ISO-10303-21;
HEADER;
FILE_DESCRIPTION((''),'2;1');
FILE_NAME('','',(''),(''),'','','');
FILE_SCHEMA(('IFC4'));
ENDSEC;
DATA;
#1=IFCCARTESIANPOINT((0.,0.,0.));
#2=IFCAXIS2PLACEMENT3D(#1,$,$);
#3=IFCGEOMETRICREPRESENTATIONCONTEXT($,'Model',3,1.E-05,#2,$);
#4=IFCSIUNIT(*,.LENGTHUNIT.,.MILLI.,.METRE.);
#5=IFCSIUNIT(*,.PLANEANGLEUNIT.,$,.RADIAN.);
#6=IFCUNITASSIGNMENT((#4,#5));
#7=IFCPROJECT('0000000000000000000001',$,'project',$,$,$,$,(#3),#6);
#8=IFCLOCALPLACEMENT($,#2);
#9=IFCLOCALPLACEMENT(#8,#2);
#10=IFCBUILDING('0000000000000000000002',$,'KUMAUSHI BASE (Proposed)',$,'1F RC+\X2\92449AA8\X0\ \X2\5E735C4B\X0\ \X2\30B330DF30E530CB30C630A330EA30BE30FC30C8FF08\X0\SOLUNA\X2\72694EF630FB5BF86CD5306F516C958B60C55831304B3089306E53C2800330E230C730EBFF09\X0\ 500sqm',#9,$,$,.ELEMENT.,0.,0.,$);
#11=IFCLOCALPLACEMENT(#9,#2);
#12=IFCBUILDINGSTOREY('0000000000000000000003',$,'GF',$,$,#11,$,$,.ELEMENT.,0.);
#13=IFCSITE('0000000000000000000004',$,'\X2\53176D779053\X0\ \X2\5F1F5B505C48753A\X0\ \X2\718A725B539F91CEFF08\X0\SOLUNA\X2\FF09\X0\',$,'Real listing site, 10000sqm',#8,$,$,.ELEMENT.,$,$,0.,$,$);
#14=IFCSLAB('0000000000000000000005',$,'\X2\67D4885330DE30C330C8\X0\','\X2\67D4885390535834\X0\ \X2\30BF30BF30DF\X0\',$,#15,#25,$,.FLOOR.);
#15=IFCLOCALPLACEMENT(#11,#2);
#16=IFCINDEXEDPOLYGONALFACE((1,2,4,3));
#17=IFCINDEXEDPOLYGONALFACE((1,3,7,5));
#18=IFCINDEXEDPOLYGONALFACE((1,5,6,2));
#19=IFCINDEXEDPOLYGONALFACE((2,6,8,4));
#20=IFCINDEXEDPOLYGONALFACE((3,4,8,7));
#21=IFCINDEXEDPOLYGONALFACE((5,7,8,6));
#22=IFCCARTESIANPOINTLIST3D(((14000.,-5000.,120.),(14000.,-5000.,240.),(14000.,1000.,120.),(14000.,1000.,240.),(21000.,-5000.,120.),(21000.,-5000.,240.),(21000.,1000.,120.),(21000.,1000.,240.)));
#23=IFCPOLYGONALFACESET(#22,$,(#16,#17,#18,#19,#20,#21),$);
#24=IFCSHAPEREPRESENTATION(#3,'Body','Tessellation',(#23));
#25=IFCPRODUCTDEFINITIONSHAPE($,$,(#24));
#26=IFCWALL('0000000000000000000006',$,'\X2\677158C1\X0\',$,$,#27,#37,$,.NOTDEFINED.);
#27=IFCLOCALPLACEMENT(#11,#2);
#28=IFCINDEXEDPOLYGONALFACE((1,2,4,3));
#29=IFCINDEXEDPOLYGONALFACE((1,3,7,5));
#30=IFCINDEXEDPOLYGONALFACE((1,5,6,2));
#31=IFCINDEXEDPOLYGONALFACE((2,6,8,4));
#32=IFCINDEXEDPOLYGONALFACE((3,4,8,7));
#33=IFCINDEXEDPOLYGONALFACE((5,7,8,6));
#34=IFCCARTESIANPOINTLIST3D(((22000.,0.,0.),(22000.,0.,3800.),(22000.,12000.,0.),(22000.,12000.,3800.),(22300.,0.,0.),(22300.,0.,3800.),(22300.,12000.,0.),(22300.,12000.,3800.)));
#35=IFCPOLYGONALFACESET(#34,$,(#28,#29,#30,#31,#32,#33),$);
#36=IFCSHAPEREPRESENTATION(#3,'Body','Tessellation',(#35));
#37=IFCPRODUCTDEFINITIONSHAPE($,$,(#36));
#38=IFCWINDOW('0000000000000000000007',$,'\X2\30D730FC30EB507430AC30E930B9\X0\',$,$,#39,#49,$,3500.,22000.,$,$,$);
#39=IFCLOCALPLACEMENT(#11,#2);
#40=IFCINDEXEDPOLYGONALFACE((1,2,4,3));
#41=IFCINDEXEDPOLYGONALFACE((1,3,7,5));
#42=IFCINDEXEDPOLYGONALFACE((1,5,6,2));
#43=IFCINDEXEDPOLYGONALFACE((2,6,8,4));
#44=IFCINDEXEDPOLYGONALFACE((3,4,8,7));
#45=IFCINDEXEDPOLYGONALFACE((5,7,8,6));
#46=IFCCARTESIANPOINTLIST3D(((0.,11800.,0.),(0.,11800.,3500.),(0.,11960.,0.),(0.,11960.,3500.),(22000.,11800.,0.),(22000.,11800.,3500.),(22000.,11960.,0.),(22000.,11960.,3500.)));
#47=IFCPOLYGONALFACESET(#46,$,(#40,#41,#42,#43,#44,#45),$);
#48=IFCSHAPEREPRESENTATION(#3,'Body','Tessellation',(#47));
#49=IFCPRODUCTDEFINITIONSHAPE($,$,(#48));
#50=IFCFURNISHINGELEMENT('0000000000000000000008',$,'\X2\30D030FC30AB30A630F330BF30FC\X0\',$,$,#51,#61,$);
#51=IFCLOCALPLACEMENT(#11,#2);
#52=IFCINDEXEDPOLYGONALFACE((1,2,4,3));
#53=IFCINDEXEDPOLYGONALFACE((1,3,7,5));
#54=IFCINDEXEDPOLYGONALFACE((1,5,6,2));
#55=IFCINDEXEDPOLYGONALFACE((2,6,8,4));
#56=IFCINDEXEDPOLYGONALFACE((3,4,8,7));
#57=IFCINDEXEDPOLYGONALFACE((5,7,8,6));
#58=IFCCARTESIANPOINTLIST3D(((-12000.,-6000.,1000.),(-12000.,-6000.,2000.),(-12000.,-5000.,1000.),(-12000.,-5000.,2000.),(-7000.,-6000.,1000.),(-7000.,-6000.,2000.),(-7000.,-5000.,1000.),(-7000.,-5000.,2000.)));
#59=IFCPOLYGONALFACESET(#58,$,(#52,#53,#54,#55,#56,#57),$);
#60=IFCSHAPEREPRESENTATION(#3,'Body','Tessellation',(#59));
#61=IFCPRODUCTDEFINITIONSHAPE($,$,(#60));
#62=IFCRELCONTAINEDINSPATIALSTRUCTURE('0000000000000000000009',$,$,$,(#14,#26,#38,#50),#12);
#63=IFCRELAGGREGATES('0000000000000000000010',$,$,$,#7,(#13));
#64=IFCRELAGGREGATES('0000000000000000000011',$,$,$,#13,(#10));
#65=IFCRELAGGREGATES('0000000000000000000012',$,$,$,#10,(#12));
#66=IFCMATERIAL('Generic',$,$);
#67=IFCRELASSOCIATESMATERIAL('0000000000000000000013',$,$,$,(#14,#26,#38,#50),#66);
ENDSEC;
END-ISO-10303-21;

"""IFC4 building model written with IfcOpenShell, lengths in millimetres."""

from ifc_helpers import new_model, si_unit, frame, frame_2d, origin, place, context, project, spatial, rectangle, extrude, material, element, fill, save


model = new_model("IFC4")

# Units and contexts
model_context = context("Model", 3, precision=1e-05, world=origin())
ifc_project = project(units=[si_unit("LENGTHUNIT", "METRE", prefix="MILLI"), si_unit("PLANEANGLEUNIT", "RADIAN")], contexts=[model_context])

# Site, building, storey
site_placement = place(None, origin())
site = spatial("IfcSite", under=ifc_project, at=site_placement, Name="北海道 弟子屈町 熊牛原野（SOLUNA）", ObjectType="Real listing site, 10000sqm", CompositionType="ELEMENT", RefElevation=0.0)
building_placement = place(site_placement, origin())
building = spatial("IfcBuilding", under=site, at=building_placement, Name="KUMAUSHI BASE (Proposed)", ObjectType="1F RC+鉄骨 平屋 コミュニティリゾート（SOLUNA物件・寸法は公開情報からの参考モデル） 500sqm", CompositionType="ELEMENT", ElevationOfRefHeight=0.0, ElevationOfTerrain=0.0)
storey_placement = place(building_placement, origin())
storey = spatial("IfcBuildingStorey", under=building, at=storey_placement, Name="GF", CompositionType="ELEMENT", Elevation=0.0)

# Slab
ifc_material_1 = material(Name="Generic")
slab_1_placement = place(storey_placement, frame((7000.0, -2500.0, 60.0)))
element("IfcSlab", 1, at=slab_1_placement, inside=storey, material=ifc_material_1, Name="柔術マット", Description="柔術道場 タタミ", PredefinedType="FLOOR", context=model_context, shape_type="SweptSolid", body=[
    extrude(rectangle(XDim=7000.0, YDim=6000.0, at=frame_2d((3500.0, 3000.0))), frame((7000.0, -2500.0, 60.0)), (0.0, 0.0, 1.0), 120.0),
])

# Wall, opening, window
wall_1_placement = place(storey_placement, frame((11000.0, 0.0, 0.0)))
wall_1 = element("IfcWall", 2, at=wall_1_placement, inside=storey, material=ifc_material_1, Name="東壁", PredefinedType="NOTDEFINED", context=model_context, shape_type="SweptSolid", body=[
    extrude(rectangle(XDim=300.0, YDim=12000.0, at=frame_2d((150.0, 6000.0))), frame((11000.0, 0.0, 0.0)), (0.0, 0.0, 1.0), 3800.0),
])
opening_placement = place(storey_placement, frame((0.0, 5900.0, 0.0)))
opening = element("IfcOpeningElement", 3, at=opening_placement, cuts=wall_1, PredefinedType="NOTDEFINED", context=model_context, shape_type="SweptSolid", body=[
    extrude(rectangle(XDim=22000.0, YDim=160.0, at=frame_2d((11000.0, 80.0))), frame((0.0, 5900.0, 0.0)), (0.0, 0.0, 1.0), 3500.0),
])
window_placement = place(storey_placement, frame((0.0, 5900.0, 0.0)))
window = element("IfcWindow", 4, at=window_placement, inside=storey, material=ifc_material_1, Name="プール側ガラス", OverallHeight=3500.0, OverallWidth=22000.0, context=model_context, shape_type="SweptSolid", body=[
    extrude(rectangle(XDim=22000.0, YDim=160.0, at=frame_2d((11000.0, 80.0))), frame((0.0, 5900.0, 0.0)), (0.0, 0.0, 1.0), 3500.0),
])
fill(opening, window)

# Furnishing element
furnishing_1_placement = place(storey_placement, frame((-6000.0, -3000.0, 500.0)))
element("IfcFurnishingElement", 5, at=furnishing_1_placement, inside=storey, material=ifc_material_1, Name="バーカウンター", context=model_context, shape_type="SweptSolid", body=[
    extrude(rectangle(XDim=5000.0, YDim=1000.0, at=frame_2d((2500.0, 500.0))), frame((-6000.0, -3000.0, 500.0)), (0.0, 0.0, 1.0), 1000.0),
])

save(model, "model.ifc")
